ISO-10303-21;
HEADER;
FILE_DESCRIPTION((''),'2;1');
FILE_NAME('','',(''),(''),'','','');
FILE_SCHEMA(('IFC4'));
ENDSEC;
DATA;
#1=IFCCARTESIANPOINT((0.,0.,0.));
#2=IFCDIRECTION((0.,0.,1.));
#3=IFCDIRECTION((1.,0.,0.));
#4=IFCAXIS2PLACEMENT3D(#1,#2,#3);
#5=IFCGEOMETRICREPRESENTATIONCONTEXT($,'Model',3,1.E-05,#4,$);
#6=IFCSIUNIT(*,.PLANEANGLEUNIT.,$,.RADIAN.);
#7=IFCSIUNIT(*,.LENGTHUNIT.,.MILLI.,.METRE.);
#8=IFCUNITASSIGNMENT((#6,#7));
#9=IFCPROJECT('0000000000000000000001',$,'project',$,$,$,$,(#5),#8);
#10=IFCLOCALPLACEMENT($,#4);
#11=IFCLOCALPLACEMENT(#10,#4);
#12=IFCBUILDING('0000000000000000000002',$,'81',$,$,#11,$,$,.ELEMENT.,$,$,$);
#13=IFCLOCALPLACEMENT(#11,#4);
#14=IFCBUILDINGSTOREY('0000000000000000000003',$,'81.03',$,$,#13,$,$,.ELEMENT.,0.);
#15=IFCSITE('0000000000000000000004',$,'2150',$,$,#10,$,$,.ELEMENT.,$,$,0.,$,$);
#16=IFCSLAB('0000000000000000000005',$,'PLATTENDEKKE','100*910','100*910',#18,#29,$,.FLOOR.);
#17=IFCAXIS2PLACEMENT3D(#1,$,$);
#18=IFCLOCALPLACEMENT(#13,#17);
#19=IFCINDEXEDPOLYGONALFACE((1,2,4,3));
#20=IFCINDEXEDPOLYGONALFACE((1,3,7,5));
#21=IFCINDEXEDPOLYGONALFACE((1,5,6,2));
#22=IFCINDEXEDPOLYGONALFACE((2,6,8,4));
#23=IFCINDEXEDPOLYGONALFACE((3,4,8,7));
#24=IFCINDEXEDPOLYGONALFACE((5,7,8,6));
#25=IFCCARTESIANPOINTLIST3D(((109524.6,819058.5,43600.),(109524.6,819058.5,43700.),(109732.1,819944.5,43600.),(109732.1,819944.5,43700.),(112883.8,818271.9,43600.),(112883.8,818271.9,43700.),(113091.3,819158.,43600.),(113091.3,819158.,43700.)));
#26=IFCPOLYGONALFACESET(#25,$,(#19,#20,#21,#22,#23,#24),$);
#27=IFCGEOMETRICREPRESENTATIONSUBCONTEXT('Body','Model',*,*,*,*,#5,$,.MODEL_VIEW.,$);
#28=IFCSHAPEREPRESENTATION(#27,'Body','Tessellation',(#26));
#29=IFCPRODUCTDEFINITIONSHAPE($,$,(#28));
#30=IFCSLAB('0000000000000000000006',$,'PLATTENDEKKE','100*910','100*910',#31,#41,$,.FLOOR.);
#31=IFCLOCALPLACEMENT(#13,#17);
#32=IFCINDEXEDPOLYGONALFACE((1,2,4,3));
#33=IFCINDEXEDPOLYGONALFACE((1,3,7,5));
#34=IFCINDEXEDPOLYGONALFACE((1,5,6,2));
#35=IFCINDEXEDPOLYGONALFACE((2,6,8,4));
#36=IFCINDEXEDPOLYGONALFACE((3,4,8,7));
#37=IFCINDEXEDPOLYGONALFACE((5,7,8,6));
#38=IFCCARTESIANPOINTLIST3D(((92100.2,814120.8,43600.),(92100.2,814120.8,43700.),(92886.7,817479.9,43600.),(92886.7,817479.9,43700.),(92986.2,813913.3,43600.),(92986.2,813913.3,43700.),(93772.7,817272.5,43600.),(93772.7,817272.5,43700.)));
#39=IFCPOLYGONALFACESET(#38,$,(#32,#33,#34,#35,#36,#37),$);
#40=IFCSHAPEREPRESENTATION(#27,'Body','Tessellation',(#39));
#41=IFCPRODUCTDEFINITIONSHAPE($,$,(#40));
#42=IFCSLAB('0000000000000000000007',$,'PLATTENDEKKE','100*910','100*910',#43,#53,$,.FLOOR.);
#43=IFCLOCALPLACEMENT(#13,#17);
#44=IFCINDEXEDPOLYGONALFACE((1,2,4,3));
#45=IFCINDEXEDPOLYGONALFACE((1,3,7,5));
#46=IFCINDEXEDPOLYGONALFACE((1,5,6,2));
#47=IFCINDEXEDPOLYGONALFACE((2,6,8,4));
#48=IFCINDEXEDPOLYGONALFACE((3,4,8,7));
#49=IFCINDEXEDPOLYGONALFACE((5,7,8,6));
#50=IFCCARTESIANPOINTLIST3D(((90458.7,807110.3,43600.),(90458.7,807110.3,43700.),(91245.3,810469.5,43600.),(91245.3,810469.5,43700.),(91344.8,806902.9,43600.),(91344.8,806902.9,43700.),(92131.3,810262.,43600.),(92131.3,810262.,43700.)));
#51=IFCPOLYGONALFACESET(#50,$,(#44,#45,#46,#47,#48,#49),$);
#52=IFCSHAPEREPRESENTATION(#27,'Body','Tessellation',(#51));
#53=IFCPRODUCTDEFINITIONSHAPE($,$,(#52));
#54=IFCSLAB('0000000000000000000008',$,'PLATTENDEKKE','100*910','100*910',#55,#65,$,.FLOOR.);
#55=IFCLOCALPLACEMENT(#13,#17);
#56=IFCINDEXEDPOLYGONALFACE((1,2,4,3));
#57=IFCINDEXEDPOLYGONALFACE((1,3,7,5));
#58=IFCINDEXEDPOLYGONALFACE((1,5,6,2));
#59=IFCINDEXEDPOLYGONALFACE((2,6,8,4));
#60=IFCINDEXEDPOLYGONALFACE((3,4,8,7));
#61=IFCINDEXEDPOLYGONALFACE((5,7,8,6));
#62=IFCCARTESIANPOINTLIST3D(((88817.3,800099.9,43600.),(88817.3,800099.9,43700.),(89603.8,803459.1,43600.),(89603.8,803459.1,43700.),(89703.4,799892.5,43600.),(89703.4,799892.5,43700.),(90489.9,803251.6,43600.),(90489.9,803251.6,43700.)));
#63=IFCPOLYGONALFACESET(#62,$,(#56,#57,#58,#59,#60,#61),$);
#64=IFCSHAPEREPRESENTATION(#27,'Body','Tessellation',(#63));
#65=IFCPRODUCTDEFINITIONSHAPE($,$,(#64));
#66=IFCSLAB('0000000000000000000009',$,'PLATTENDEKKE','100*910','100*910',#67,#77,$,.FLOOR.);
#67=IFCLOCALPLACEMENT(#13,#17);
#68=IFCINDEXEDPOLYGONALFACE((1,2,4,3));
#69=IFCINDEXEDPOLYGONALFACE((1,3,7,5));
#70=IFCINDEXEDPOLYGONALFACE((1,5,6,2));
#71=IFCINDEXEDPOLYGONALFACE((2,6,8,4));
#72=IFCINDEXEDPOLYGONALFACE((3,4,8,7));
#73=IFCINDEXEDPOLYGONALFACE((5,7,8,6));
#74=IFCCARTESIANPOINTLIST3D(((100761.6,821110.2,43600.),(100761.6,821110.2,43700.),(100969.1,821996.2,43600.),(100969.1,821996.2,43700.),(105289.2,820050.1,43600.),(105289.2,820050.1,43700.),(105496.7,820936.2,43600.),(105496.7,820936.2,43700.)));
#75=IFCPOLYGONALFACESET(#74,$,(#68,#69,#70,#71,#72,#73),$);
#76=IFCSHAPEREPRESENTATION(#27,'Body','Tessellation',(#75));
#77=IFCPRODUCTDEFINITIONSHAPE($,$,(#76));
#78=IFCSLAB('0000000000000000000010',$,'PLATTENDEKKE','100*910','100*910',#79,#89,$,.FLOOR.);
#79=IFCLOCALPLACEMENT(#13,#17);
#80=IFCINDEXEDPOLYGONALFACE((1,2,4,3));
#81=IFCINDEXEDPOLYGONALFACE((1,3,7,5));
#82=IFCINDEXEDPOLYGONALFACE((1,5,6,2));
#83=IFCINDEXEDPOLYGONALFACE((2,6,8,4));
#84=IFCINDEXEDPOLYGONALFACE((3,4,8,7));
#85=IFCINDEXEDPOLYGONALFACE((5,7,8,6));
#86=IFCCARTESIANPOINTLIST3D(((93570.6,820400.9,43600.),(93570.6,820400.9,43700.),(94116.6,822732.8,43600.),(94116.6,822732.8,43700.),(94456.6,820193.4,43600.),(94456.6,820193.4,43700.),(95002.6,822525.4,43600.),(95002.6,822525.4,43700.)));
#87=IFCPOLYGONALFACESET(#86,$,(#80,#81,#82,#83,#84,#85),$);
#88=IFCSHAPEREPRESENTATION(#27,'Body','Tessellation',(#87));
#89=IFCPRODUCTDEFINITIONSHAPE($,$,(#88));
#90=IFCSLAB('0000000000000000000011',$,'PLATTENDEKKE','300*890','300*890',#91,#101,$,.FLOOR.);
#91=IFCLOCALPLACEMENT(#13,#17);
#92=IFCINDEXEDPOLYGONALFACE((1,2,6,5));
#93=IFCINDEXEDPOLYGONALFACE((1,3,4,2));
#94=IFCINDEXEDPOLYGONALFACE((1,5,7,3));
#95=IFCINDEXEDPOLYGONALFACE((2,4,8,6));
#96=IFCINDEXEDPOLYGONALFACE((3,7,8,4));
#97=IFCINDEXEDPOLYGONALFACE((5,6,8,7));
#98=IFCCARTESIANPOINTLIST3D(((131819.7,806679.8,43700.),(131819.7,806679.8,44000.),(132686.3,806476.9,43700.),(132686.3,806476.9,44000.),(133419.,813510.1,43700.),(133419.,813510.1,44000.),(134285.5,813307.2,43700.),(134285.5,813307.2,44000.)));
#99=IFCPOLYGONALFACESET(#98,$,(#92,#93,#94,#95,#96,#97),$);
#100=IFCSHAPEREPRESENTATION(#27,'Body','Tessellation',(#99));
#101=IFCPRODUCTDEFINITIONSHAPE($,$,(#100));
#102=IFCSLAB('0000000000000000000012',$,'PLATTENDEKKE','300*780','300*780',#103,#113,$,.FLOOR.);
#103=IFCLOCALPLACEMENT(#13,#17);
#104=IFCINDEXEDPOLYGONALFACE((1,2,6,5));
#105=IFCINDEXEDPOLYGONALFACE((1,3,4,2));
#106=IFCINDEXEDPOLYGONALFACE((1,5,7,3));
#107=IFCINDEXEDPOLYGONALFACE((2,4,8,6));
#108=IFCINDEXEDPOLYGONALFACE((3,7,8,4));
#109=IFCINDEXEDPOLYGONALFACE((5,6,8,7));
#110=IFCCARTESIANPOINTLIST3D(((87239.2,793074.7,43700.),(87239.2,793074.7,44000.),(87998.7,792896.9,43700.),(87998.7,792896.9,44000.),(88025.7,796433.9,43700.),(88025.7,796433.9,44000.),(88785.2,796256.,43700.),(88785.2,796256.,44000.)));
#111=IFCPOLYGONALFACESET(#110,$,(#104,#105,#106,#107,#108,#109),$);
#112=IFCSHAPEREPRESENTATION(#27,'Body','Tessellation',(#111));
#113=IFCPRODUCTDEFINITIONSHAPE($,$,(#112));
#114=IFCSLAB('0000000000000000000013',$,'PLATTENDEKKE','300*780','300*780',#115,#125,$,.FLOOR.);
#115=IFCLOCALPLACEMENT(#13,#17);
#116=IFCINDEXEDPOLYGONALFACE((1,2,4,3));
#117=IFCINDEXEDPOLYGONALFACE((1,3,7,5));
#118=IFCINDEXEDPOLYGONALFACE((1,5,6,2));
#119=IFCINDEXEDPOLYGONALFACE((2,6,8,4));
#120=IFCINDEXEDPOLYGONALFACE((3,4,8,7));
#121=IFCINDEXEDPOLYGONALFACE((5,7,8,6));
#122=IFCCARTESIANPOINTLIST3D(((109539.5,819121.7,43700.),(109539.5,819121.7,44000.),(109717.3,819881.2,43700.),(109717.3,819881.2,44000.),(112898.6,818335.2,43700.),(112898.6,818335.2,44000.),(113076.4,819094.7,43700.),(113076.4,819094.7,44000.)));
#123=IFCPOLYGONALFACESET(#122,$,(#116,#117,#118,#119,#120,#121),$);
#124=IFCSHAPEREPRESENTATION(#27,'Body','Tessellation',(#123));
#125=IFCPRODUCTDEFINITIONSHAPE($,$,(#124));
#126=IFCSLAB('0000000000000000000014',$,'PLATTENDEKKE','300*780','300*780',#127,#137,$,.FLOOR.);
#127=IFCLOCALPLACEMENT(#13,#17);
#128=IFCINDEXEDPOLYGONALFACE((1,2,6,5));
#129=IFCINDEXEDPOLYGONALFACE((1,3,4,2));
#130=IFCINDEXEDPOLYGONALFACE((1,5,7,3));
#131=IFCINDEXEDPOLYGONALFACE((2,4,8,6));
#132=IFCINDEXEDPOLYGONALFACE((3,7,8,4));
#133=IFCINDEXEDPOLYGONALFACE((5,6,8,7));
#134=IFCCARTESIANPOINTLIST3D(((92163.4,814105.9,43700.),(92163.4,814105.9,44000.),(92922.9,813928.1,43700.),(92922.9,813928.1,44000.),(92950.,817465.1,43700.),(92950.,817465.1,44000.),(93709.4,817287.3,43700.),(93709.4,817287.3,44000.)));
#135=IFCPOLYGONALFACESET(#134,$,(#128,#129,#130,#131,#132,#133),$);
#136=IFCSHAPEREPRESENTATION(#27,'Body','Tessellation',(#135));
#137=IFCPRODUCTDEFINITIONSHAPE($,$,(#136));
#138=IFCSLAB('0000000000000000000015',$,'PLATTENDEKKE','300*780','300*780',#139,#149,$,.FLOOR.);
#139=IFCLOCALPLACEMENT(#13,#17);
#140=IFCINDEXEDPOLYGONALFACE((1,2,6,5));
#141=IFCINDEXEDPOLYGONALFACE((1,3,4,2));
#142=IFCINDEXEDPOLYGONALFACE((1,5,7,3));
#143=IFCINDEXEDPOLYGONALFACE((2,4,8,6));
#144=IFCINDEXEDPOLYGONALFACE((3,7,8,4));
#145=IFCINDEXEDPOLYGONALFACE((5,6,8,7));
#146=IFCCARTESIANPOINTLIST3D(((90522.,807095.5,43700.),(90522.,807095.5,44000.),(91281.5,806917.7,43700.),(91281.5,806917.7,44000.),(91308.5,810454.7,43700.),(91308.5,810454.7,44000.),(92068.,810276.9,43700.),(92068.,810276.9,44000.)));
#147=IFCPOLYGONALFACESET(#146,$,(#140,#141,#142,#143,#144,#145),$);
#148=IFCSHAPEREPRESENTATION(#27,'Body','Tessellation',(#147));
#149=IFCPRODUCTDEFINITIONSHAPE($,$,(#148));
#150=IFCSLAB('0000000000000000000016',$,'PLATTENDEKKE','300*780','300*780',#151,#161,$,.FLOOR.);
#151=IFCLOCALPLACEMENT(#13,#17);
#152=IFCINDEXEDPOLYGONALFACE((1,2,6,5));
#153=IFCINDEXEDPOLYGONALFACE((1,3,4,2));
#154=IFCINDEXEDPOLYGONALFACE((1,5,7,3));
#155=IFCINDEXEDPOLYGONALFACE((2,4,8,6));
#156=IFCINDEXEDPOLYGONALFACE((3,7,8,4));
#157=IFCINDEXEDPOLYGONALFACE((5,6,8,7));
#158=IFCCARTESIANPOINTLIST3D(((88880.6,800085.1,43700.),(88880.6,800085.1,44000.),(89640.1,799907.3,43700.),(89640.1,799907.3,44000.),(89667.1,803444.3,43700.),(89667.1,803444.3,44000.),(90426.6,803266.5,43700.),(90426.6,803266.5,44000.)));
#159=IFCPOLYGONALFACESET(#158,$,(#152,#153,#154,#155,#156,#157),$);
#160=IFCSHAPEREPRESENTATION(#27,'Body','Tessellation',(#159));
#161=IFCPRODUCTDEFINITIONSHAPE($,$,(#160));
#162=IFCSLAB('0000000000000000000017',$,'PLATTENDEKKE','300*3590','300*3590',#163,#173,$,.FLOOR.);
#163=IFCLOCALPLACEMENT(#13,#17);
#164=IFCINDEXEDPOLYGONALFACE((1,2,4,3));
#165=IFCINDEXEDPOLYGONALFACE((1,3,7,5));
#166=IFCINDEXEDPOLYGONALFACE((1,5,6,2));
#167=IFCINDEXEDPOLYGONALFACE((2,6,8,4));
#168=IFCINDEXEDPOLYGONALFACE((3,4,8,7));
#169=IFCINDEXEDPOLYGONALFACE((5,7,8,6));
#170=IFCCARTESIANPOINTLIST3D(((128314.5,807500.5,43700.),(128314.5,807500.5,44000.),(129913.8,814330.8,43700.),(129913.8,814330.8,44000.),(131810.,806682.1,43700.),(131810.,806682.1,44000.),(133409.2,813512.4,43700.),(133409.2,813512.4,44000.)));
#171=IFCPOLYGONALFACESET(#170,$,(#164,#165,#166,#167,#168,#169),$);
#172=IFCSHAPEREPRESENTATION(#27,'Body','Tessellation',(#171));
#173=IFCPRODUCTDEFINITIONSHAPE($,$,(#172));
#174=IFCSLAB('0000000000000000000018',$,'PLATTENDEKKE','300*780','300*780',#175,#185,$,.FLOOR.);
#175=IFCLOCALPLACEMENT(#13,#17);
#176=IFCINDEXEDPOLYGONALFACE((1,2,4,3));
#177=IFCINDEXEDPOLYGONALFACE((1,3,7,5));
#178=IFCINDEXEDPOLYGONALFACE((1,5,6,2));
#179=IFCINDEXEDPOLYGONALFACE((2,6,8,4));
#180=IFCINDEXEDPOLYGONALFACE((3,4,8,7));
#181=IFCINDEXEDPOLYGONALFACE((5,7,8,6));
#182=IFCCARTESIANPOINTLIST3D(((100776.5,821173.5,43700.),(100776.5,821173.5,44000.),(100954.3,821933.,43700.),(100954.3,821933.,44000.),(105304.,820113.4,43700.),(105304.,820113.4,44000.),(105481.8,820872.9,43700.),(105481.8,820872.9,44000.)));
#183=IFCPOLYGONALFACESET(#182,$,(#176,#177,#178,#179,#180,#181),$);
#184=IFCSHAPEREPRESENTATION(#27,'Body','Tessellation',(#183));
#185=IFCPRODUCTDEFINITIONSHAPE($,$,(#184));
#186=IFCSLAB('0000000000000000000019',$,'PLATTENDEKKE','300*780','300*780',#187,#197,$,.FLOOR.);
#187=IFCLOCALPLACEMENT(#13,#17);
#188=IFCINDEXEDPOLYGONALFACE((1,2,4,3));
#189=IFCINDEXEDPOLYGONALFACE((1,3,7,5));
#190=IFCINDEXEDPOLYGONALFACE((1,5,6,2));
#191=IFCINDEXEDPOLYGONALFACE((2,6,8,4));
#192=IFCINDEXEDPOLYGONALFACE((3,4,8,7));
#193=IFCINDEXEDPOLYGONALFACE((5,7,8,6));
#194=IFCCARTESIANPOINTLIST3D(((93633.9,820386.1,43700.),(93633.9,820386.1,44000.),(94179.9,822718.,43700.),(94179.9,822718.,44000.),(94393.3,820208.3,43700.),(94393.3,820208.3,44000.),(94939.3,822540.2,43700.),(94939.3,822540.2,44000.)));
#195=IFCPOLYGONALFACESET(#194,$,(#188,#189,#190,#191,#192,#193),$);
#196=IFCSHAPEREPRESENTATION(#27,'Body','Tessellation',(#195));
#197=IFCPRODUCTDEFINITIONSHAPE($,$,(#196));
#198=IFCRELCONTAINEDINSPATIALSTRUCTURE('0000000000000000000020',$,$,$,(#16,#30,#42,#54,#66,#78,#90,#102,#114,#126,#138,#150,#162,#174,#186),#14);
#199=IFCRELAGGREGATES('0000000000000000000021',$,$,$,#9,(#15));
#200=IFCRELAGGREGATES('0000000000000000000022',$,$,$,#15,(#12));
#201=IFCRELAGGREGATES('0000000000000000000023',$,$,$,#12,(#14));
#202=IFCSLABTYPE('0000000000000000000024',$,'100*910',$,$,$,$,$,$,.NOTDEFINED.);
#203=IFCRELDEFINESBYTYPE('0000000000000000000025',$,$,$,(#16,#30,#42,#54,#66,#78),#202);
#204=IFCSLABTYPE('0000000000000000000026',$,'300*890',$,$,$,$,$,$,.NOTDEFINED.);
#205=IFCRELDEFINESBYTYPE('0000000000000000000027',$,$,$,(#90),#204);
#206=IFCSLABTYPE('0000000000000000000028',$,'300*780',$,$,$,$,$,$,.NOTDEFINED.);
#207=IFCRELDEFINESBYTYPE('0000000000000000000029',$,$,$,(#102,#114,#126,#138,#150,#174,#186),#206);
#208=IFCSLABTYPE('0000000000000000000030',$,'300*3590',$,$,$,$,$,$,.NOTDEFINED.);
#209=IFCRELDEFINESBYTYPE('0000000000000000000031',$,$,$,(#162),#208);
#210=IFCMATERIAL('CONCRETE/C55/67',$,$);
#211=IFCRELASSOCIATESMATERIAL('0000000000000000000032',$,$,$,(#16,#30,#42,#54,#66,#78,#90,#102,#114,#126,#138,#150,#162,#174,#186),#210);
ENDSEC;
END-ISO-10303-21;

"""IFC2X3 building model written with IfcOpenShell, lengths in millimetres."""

from ifc_helpers import new_model, si_unit, frame, origin, origin_with_axes, origin_2d_with_axis, place, context, subcontext, project, spatial, rectangle, extrude, source, transform, mapped, material, type_object, element, save


model = new_model("IFC2X3")

# Units and contexts
model_context = context("Model", 3, precision=1e-05, world=origin_with_axes())
body_context = subcontext(model_context, "Body", "Model", "MODEL_VIEW")
ifc_project = project(units=[si_unit("PLANEANGLEUNIT", "RADIAN"), si_unit("LENGTHUNIT", "METRE", prefix="MILLI")], contexts=[model_context])

# Site, building, storey
site_placement = place(None, origin_with_axes())
site = spatial("IfcSite", under=ifc_project, at=site_placement, Name="2150", CompositionType="ELEMENT", RefElevation=0.0)
building_placement = place(site_placement, origin_with_axes())
building = spatial("IfcBuilding", under=site, at=building_placement, Name="81", CompositionType="ELEMENT")
storey_placement = place(building_placement, origin_with_axes())
storey = spatial("IfcBuildingStorey", under=building, at=storey_placement, Name="81.03", CompositionType="ELEMENT", Elevation=0.0)

# Slabs
ifc_material = material(Name="CONCRETE/C55/67")
slab_type_1 = type_object("IfcSlabType", Name="100*910", PredefinedType="NOTDEFINED")
shared_shape_1 = source(origin(), body_context, "Body", "SweptSolid", [
    extrude(rectangle(XDim=910.0, YDim=100.0, at=origin_2d_with_axis()), frame((3450.0, 0.0, 0.0), z_axis=(-1.0, 0.0, 0.0), x_axis=(0.0, -1.0, 0.0)), (0.0, 0.0, 1.0), 3450.0),
])
for number, where, z_axis, x_axis, name in (
    (1, (112987.5, 818715.0, 43650.0), (0.0, 0.0, 1.0), (-0.973667, 0.227973, 0.0), "PLATTENDEKKE"),
    (2, (93329.7, 817376.2, 43650.0), (0.0, 0.0, 1.0), (-0.227973, -0.973667, 0.0), "PLATTENDEKKE"),
    (3, (91688.3, 810365.8, 43650.0), (0.0, 0.0, 1.0), (-0.227973, -0.973667, 0.0), "PLATTENDEKKE"),
    (4, (90046.9, 803355.4, 43650.0), (0.0, 0.0, 1.0), (-0.227973, -0.973667, 0.0), "PLATTENDEKKE"),
):
    element("IfcSlab", number, at=place(storey_placement, frame(where, z_axis=z_axis, x_axis=x_axis)), inside=storey, type_object=slab_type_1, material=ifc_material, Name=name, Description="100*910", ObjectType="100*910", PredefinedType="FLOOR", context=body_context, shape_type="MappedRepresentation", body=[
        mapped(shared_shape_1, transform((0.0, 0.0, 0.0))),
    ])
shared_shape_2 = source(origin(), body_context, "Body", "SweptSolid", [
    extrude(rectangle(XDim=910.0, YDim=100.0, at=origin_2d_with_axis()), frame((4650.0, 0.0, 0.0), z_axis=(-1.0, 0.0, 0.0), x_axis=(0.0, -1.0, 0.0)), (0.0, 0.0, 1.0), 4650.0),
])
slab_1_placement = place(storey_placement, frame((105392.9, 820493.2, 43650.0), z_axis=(0.0, 0.0, 1.0), x_axis=(-0.973667, 0.227973, 0.0)))
element("IfcSlab", 5, at=slab_1_placement, inside=storey, type_object=slab_type_1, material=ifc_material, Name="PLATTENDEKKE", Description="100*910", ObjectType="100*910", PredefinedType="FLOOR", context=body_context, shape_type="MappedRepresentation", body=[
    mapped(shared_shape_2, transform((0.0, 0.0, 0.0))),
])
shared_shape_3 = source(origin(), body_context, "Body", "SweptSolid", [
    extrude(rectangle(XDim=910.0, YDim=100.0, at=origin_2d_with_axis()), frame((2395.0, 0.0, 0.0), z_axis=(-1.0, 0.0, 0.0), x_axis=(0.0, -1.0, 0.0)), (0.0, 0.0, 1.0), 2395.0),
])
slab_2_placement = place(storey_placement, frame((94559.6, 822629.1, 43650.0), z_axis=(0.0, 0.0, 1.0), x_axis=(-0.227973, -0.973667, 0.0)))
element("IfcSlab", 6, at=slab_2_placement, inside=storey, type_object=slab_type_1, material=ifc_material, Name="PLATTENDEKKE", Description="100*910", ObjectType="100*910", PredefinedType="FLOOR", context=body_context, shape_type="MappedRepresentation", body=[
    mapped(shared_shape_3, transform((0.0, 0.0, 0.0))),
])
slab_type_2 = type_object("IfcSlabType", Name="300*890", PredefinedType="NOTDEFINED")
shared_shape_4 = source(origin(), body_context, "Body", "SweptSolid", [
    extrude(rectangle(XDim=890.0, YDim=300.0, at=origin_2d_with_axis()), frame((7015.0, 0.0, 0.0), z_axis=(-1.0, 0.0, 0.0), x_axis=(0.0, -1.0, 0.0)), (0.0, 0.0, 1.0), 7015.0),
])
slab_3_placement = place(storey_placement, frame((132253.0, 806578.4, 43850.0), z_axis=(0.0, 0.0, 1.0), x_axis=(0.227973, 0.973667, 0.0)))
element("IfcSlab", 7, at=slab_3_placement, inside=storey, type_object=slab_type_2, material=ifc_material, Name="PLATTENDEKKE", Description="300*890", ObjectType="300*890", PredefinedType="FLOOR", context=body_context, shape_type="MappedRepresentation", body=[
    mapped(shared_shape_4, transform((0.0, 0.0, 0.0))),
])
slab_type_3 = type_object("IfcSlabType", Name="300*780", PredefinedType="NOTDEFINED")
shared_shape_5 = source(origin(), body_context, "Body", "SweptSolid", [
    extrude(rectangle(XDim=780.0, YDim=300.0, at=origin_2d_with_axis()), frame((3450.0, 0.0, 0.0), z_axis=(-1.0, 0.0, 0.0), x_axis=(0.0, -1.0, 0.0)), (0.0, 0.0, 1.0), 3450.0),
])
for number, where, z_axis, x_axis, name in (
    (8, (88405.5, 796345.0, 43850.0), (0.0, 0.0, 1.0), (-0.227973, -0.973667, 0.0), "PLATTENDEKKE"),
    (9, (112987.5, 818715.0, 43850.0), (0.0, 0.0, 1.0), (-0.973667, 0.227973, 0.0), "PLATTENDEKKE"),
    (10, (93329.7, 817376.2, 43850.0), (0.0, 0.0, 1.0), (-0.227973, -0.973667, 0.0), "PLATTENDEKKE"),
    (11, (91688.3, 810365.8, 43850.0), (0.0, 0.0, 1.0), (-0.227973, -0.973667, 0.0), "PLATTENDEKKE"),
    (12, (90046.9, 803355.4, 43850.0), (0.0, 0.0, 1.0), (-0.227973, -0.973667, 0.0), "PLATTENDEKKE"),
):
    element("IfcSlab", number, at=place(storey_placement, frame(where, z_axis=z_axis, x_axis=x_axis)), inside=storey, type_object=slab_type_3, material=ifc_material, Name=name, Description="300*780", ObjectType="300*780", PredefinedType="FLOOR", context=body_context, shape_type="MappedRepresentation", body=[
        mapped(shared_shape_5, transform((0.0, 0.0, 0.0))),
    ])
slab_type_4 = type_object("IfcSlabType", Name="300*3590", PredefinedType="NOTDEFINED")
shared_shape_6 = source(origin(), body_context, "Body", "SweptSolid", [
    extrude(rectangle(XDim=3590.0, YDim=300.0, at=origin_2d_with_axis()), frame((7015.0, 0.0, 0.0), z_axis=(-1.0, 0.0, 0.0), x_axis=(0.0, -1.0, 0.0)), (0.0, 0.0, 1.0), 7015.0),
])
slab_4_placement = place(storey_placement, frame((130062.3, 807091.3, 43850.0), z_axis=(0.0, 0.0, 1.0), x_axis=(0.227973, 0.973667, 0.0)))
element("IfcSlab", 13, at=slab_4_placement, inside=storey, type_object=slab_type_4, material=ifc_material, Name="PLATTENDEKKE", Description="300*3590", ObjectType="300*3590", PredefinedType="FLOOR", context=body_context, shape_type="MappedRepresentation", body=[
    mapped(shared_shape_6, transform((0.0, 0.0, 0.0))),
])
shared_shape_7 = source(origin(), body_context, "Body", "SweptSolid", [
    extrude(rectangle(XDim=780.0, YDim=300.0, at=origin_2d_with_axis()), frame((4650.0, 0.0, 0.0), z_axis=(-1.0, 0.0, 0.0), x_axis=(0.0, -1.0, 0.0)), (0.0, 0.0, 1.0), 4650.0),
])
slab_5_placement = place(storey_placement, frame((105392.9, 820493.2, 43850.0), z_axis=(0.0, 0.0, 1.0), x_axis=(-0.973667, 0.227973, 0.0)))
element("IfcSlab", 14, at=slab_5_placement, inside=storey, type_object=slab_type_3, material=ifc_material, Name="PLATTENDEKKE", Description="300*780", ObjectType="300*780", PredefinedType="FLOOR", context=body_context, shape_type="MappedRepresentation", body=[
    mapped(shared_shape_7, transform((0.0, 0.0, 0.0))),
])
shared_shape_8 = source(origin(), body_context, "Body", "SweptSolid", [
    extrude(rectangle(XDim=780.0, YDim=300.0, at=origin_2d_with_axis()), frame((2395.0, 0.0, 0.0), z_axis=(-1.0, 0.0, 0.0), x_axis=(0.0, -1.0, 0.0)), (0.0, 0.0, 1.0), 2395.0),
])
slab_6_placement = place(storey_placement, frame((94559.6, 822629.1, 43850.0), z_axis=(0.0, 0.0, 1.0), x_axis=(-0.227973, -0.973667, 0.0)))
element("IfcSlab", 15, at=slab_6_placement, inside=storey, type_object=slab_type_3, material=ifc_material, Name="PLATTENDEKKE", Description="300*780", ObjectType="300*780", PredefinedType="FLOOR", context=body_context, shape_type="MappedRepresentation", body=[
    mapped(shared_shape_8, transform((0.0, 0.0, 0.0))),
])

save(model, "model.ifc")
